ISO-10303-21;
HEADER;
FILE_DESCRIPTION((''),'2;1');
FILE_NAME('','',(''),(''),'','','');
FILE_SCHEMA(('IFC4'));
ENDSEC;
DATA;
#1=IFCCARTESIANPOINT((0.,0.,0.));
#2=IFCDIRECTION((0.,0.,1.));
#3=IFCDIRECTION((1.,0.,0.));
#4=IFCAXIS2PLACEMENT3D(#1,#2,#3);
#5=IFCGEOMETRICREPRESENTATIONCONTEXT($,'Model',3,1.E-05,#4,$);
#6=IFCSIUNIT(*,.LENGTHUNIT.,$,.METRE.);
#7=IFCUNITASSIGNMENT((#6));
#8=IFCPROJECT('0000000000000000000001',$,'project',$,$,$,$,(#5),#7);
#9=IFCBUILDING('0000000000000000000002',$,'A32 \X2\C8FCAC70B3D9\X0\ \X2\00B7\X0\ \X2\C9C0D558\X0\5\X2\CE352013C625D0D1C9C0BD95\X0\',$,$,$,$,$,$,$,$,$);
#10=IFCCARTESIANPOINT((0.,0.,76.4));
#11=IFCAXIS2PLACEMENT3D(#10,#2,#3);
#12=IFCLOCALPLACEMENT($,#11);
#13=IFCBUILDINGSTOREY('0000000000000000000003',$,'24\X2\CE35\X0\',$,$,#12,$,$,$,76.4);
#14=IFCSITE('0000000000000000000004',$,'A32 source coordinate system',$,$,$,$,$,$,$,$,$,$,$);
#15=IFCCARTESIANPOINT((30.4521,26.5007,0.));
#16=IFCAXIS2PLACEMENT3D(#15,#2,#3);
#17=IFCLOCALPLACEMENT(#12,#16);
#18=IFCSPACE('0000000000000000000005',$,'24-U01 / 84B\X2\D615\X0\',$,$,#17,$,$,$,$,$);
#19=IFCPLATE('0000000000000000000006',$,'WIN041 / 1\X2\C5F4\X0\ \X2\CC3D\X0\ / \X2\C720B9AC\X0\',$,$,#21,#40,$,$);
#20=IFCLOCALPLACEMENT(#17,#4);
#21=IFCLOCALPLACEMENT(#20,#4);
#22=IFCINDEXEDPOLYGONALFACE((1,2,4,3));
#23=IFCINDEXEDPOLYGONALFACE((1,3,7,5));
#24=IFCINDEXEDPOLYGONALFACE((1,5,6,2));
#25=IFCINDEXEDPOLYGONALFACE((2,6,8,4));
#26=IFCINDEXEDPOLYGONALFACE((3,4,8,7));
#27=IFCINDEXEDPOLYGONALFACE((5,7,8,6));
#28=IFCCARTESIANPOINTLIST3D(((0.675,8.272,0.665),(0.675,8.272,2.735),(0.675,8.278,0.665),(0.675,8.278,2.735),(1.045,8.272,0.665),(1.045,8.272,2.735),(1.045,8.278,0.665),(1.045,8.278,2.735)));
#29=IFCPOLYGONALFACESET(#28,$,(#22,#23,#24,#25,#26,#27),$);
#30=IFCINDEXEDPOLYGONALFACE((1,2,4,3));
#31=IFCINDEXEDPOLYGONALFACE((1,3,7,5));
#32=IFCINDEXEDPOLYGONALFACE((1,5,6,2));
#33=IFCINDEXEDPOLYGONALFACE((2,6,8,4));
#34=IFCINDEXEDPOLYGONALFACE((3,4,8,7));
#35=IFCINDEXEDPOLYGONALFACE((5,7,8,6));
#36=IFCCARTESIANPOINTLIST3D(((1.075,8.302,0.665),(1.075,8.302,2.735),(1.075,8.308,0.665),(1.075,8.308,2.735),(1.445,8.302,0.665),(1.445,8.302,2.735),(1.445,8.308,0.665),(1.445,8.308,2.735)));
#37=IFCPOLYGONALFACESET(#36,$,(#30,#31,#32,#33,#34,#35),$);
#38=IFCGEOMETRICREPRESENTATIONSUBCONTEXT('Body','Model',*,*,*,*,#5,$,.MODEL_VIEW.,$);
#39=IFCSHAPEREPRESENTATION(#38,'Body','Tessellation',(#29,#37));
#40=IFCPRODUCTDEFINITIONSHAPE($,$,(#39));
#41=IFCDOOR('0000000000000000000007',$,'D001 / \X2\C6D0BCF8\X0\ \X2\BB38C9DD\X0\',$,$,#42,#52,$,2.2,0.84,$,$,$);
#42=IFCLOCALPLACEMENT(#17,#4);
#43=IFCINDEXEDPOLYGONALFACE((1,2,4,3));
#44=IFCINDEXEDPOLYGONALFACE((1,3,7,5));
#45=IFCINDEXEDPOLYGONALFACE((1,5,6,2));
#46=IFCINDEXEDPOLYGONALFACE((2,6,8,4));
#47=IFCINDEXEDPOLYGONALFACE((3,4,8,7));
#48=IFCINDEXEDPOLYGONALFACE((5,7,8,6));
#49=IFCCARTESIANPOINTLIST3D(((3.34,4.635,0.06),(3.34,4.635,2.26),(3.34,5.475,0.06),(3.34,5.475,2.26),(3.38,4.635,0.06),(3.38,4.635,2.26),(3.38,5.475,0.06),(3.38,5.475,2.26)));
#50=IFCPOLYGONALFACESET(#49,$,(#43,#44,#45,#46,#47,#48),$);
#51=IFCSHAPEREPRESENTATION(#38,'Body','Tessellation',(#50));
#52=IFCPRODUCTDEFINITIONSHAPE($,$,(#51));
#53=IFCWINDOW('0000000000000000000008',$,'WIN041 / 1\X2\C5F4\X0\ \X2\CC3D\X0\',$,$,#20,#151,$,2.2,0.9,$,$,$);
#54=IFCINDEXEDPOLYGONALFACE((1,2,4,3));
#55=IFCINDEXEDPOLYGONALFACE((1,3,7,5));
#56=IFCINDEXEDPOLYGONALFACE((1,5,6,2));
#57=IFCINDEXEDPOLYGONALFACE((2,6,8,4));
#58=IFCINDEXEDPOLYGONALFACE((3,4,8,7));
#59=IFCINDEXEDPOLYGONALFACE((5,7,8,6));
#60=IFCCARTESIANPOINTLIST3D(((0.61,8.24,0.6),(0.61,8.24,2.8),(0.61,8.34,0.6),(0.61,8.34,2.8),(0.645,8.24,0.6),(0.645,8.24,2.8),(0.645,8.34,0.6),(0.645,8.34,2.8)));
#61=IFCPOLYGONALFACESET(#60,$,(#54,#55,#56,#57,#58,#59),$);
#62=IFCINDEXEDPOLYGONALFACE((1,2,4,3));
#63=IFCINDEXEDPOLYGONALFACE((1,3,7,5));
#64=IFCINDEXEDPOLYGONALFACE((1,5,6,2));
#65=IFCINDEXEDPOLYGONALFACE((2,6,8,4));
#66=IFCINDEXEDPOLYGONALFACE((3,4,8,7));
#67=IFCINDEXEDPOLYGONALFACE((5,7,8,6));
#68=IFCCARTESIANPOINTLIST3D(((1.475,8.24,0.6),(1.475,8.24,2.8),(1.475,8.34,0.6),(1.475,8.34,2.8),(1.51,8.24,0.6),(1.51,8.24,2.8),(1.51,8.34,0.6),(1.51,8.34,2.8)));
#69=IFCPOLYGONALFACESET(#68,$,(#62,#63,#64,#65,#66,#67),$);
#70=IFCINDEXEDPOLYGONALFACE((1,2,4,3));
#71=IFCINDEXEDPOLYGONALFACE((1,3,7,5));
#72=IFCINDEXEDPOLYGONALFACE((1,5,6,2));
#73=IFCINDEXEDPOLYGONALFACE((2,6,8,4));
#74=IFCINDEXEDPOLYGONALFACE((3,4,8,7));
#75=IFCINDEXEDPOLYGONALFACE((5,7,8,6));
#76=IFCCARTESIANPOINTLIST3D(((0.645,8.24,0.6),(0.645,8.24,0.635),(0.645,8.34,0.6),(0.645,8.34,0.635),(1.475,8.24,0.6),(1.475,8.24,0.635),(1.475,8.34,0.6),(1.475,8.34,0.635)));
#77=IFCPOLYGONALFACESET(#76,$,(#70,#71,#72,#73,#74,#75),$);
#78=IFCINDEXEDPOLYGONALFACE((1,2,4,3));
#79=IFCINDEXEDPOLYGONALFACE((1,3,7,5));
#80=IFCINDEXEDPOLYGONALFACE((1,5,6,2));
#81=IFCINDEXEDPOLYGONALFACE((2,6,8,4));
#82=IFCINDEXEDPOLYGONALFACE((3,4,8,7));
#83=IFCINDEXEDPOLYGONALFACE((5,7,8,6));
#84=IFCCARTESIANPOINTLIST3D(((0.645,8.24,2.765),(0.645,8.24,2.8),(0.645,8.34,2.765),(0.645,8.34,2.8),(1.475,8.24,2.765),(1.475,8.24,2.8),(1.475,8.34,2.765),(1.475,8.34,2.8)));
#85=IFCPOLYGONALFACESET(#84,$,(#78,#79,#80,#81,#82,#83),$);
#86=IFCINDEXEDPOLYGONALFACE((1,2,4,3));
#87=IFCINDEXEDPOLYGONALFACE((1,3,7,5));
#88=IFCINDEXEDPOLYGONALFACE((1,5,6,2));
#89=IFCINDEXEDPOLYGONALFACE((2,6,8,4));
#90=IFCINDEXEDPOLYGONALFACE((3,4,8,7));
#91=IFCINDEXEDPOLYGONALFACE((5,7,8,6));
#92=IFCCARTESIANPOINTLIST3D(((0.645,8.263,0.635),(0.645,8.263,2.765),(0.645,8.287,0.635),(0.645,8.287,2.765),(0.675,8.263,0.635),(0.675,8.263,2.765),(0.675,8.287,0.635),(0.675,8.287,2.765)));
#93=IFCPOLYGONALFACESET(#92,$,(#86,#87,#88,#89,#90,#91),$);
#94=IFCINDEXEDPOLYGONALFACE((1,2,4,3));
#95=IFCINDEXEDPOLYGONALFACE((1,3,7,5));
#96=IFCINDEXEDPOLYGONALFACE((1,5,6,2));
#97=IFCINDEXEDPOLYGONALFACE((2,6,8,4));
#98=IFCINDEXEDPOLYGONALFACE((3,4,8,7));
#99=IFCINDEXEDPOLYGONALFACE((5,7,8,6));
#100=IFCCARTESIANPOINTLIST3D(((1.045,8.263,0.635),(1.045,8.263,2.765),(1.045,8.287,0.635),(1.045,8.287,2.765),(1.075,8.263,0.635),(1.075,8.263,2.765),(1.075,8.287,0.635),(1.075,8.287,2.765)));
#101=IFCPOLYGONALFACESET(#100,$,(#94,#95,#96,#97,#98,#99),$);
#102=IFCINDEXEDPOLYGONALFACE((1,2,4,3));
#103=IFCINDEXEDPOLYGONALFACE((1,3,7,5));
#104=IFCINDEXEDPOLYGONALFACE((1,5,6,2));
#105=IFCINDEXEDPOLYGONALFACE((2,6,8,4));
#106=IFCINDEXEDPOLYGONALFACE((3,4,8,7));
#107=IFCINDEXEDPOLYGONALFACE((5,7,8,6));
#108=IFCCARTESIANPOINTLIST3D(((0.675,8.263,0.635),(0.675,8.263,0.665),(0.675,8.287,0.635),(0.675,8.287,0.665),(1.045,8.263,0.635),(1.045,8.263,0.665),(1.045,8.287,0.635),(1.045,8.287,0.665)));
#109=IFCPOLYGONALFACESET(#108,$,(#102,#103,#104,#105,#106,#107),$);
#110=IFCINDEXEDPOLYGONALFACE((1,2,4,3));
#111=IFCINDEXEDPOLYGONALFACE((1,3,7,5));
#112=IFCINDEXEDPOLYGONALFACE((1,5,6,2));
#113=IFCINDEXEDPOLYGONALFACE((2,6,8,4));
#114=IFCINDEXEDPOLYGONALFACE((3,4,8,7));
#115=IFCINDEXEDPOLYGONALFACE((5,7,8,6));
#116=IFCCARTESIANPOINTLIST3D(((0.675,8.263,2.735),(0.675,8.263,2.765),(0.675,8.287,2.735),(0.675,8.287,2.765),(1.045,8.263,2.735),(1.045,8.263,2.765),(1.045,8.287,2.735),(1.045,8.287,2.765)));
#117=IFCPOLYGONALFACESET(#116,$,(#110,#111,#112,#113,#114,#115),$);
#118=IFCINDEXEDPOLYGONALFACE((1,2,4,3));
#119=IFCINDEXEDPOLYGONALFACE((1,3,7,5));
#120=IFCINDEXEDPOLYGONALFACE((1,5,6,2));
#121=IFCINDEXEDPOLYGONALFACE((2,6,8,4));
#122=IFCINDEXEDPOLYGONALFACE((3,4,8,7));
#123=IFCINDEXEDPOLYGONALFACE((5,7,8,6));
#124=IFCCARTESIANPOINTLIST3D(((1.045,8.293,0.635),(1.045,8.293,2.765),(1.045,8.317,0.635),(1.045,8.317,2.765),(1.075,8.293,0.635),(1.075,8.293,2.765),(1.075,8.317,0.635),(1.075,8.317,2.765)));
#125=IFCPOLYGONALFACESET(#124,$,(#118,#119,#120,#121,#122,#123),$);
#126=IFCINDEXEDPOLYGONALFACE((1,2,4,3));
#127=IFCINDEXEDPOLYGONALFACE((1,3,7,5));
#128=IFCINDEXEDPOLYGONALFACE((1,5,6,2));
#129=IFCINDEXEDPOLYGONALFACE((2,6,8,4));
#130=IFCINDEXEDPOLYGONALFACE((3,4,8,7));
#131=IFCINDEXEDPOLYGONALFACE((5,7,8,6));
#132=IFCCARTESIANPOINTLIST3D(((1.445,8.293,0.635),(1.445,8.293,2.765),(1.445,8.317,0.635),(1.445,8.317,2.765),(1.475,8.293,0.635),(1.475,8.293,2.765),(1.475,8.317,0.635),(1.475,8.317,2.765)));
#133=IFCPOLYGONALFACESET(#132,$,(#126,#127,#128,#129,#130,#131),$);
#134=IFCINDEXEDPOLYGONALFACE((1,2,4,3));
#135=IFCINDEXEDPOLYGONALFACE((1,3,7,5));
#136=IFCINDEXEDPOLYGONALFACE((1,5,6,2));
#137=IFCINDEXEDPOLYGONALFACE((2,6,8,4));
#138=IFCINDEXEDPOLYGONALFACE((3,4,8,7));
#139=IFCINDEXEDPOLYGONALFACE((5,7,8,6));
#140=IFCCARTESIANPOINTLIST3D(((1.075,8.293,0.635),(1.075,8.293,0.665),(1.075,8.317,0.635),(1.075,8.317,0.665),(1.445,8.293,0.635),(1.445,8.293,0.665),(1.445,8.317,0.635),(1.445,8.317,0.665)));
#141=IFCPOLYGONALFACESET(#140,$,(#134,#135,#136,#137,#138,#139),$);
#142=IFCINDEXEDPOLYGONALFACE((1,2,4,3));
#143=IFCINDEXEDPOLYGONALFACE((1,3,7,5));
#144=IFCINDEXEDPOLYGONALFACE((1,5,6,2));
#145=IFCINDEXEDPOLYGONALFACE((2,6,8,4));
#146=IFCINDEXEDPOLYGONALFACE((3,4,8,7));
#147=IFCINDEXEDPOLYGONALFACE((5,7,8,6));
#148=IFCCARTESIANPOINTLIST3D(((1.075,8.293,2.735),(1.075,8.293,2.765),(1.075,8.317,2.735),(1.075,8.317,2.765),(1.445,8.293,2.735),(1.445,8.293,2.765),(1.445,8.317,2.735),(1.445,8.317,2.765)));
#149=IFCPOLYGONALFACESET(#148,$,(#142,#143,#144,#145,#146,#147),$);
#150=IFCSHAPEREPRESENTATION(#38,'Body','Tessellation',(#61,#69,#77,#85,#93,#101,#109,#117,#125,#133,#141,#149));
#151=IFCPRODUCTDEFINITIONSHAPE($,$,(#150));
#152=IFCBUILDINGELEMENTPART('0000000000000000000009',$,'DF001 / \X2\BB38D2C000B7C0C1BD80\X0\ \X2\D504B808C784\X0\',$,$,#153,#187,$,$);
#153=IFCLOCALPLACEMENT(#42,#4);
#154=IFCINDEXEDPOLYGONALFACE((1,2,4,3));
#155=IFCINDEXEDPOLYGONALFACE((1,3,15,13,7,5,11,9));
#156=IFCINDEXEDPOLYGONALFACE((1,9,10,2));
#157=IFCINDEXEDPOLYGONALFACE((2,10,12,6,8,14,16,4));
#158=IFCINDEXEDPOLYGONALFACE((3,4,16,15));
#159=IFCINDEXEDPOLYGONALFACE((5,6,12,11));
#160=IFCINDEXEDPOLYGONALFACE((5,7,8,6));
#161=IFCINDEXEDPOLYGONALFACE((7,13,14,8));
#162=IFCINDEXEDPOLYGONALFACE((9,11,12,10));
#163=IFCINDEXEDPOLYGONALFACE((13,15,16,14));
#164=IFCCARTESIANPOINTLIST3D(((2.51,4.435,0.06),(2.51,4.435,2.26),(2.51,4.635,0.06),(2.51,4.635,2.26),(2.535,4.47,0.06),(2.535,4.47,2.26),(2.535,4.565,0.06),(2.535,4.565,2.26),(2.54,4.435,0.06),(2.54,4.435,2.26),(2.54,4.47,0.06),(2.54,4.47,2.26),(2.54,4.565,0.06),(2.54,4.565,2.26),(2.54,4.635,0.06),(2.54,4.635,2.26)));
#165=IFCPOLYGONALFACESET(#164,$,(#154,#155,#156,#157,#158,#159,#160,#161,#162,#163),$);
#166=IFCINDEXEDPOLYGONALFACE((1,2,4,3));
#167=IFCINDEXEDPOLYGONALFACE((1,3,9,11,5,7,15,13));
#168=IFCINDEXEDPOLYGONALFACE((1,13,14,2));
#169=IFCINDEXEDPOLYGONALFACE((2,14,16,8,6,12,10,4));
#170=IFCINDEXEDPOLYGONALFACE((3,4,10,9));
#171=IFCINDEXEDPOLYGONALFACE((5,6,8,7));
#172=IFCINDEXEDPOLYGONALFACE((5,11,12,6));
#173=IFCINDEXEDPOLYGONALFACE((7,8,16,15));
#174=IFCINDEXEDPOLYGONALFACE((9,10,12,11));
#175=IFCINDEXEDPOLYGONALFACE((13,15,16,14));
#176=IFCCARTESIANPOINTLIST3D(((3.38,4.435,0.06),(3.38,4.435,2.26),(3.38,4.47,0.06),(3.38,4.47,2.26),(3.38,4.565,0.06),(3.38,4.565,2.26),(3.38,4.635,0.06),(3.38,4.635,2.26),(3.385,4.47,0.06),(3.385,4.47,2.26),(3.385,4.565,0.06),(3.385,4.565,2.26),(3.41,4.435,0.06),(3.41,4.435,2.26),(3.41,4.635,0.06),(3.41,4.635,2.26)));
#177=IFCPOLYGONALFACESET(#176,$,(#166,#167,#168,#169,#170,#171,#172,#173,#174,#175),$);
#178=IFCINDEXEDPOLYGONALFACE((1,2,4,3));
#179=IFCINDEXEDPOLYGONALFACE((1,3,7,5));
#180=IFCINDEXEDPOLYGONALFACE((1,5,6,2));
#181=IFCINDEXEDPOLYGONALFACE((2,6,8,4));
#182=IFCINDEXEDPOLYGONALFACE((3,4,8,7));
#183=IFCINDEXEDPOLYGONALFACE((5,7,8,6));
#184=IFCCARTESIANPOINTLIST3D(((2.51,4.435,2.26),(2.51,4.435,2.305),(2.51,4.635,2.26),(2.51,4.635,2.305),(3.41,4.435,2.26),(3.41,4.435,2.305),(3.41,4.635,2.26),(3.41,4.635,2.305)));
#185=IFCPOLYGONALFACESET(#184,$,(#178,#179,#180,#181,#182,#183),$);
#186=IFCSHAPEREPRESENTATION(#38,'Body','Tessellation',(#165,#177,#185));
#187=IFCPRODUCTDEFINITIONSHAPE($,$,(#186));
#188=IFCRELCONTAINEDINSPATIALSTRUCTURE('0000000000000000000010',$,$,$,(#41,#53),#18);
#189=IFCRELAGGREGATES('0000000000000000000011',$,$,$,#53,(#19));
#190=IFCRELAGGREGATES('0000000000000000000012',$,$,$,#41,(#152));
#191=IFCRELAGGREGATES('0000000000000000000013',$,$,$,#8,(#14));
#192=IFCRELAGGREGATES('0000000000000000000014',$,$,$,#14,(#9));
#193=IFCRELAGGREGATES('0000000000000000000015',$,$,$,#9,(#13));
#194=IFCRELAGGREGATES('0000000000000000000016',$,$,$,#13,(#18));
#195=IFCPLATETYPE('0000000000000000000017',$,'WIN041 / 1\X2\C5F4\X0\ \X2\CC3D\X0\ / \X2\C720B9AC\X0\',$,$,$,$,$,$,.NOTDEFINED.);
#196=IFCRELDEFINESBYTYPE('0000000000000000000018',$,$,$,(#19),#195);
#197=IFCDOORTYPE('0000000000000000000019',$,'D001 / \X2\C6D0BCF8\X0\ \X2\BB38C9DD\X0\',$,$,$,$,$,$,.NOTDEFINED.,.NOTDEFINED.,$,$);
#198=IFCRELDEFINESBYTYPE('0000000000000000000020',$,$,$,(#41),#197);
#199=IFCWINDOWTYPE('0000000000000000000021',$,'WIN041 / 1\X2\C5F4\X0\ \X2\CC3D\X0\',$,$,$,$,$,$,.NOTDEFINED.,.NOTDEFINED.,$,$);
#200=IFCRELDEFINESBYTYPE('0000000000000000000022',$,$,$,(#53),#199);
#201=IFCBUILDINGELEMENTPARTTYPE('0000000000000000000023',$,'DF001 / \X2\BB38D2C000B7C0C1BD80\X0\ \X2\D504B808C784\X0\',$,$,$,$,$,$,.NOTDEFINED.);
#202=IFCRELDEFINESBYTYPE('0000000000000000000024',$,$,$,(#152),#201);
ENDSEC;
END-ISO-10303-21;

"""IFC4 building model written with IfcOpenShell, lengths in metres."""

from ifc_helpers import new_model, si_unit, frame, origin, origin_with_axes, place, context, subcontext, project, spatial, polyline, outline, extrude, source, transform, mapped, type_object, type_shapes, element, aggregate, save


model = new_model("IFC4")

# Units and contexts
model_context = context("Model", 3, precision=1e-05, world=origin_with_axes())
body_context = subcontext(model_context, "Body", "Model", "MODEL_VIEW")
ifc_project = project(units=[si_unit("LENGTHUNIT", "METRE")], contexts=[model_context])

# Plate
storey_placement = place(None, frame((0.0, 0.0, 76.4), z_axis=(0.0, 0.0, 1.0), x_axis=(1.0, 0.0, 0.0)))
space_placement = place(storey_placement, frame((30.4521, 26.5007, 0.0), z_axis=(0.0, 0.0, 1.0), x_axis=(1.0, 0.0, 0.0)))
plate_type_1 = type_object("IfcPlateType", Name="WIN041 / 1열 창 / 유리", PredefinedType="NOTDEFINED")
shared_shape_1 = source(origin(), body_context, "Body", "SweptSolid", [
    extrude(outline(polyline([(0.675, 8.272), (0.675, 8.278), (1.045, 8.278), (1.045, 8.272), (0.675, 8.272)])), frame((0.0, 0.0, 0.665)), (0.0, 0.0, 1.0), 2.07),
    extrude(outline(polyline([(1.075, 8.302), (1.075, 8.308), (1.445, 8.308), (1.445, 8.302), (1.075, 8.302)])), frame((0.0, 0.0, 0.665)), (0.0, 0.0, 1.0), 2.07),
])
type_shapes(plate_type_1, [shared_shape_1])
window_1_placement = place(space_placement, origin_with_axes())
plate_1_placement = place(window_1_placement, origin_with_axes())
plate_1 = element("IfcPlate", 1, at=plate_1_placement, type_object=plate_type_1, Name="WIN041 / 1열 창 / 유리", context=body_context, shape_type="MappedRepresentation", body=[
    mapped(shared_shape_1, transform((0.0, 0.0, 0.0), scale=1.0)),
])

# Site, building, storey, space
site = spatial("IfcSite", under=ifc_project, Name="A32 source coordinate system")
building = spatial("IfcBuilding", under=site, Name="A32 주거동 · 지하5층–옥탑지붕")
storey = spatial("IfcBuildingStorey", under=building, at=storey_placement, Name="24층", Elevation=76.4)
space = spatial("IfcSpace", under=storey, at=space_placement, Name="24-U01 / 84B형")

# Door
door_type_1 = type_object("IfcDoorType", Name="D001 / 원본 문짝", OperationType="NOTDEFINED", PredefinedType="NOTDEFINED")
shared_shape_2 = source(origin(), body_context, "Body", "SweptSolid", [
    extrude(outline(polyline([(3.34, 5.475), (3.38, 5.475), (3.38, 4.635), (3.34, 4.635), (3.34, 5.475)])), frame((0.0, 0.0, 0.06)), (0.0, 0.0, 1.0), 2.2),
])
type_shapes(door_type_1, [shared_shape_2])
door_1_placement = place(space_placement, origin_with_axes())
door_1 = element("IfcDoor", 2, at=door_1_placement, inside=space, type_object=door_type_1, Name="D001 / 원본 문짝", OverallHeight=2.2, OverallWidth=0.84, context=body_context, shape_type="MappedRepresentation", body=[
    mapped(shared_shape_2, transform((0.0, 0.0, 0.0), scale=1.0)),
])

# Window
window_type_1 = type_object("IfcWindowType", Name="WIN041 / 1열 창", PartitioningType="NOTDEFINED", PredefinedType="NOTDEFINED")
shared_shape_3 = source(origin(), body_context, "Body", "SweptSolid", [
    extrude(outline(polyline([(0.61, 8.24), (0.61, 8.34), (0.645, 8.34), (0.645, 8.24), (0.61, 8.24)])), frame((0.0, 0.0, 0.6)), (0.0, 0.0, 1.0), 2.2),
    extrude(outline(polyline([(1.475, 8.24), (1.475, 8.34), (1.51, 8.34), (1.51, 8.24), (1.475, 8.24)])), frame((0.0, 0.0, 0.6)), (0.0, 0.0, 1.0), 2.2),
    extrude(outline(polyline([(0.645, 8.24), (0.645, 8.34), (1.475, 8.34), (1.475, 8.24), (0.645, 8.24)])), frame((0.0, 0.0, 0.6)), (0.0, 0.0, 1.0), 0.035),
    extrude(outline(polyline([(0.645, 8.24), (0.645, 8.34), (1.475, 8.34), (1.475, 8.24), (0.645, 8.24)])), frame((0.0, 0.0, 2.765)), (0.0, 0.0, 1.0), 0.035),
    extrude(outline(polyline([(0.645, 8.263), (0.645, 8.287), (0.675, 8.287), (0.675, 8.263), (0.645, 8.263)])), frame((0.0, 0.0, 0.635)), (0.0, 0.0, 1.0), 2.13),
    extrude(outline(polyline([(1.045, 8.263), (1.045, 8.287), (1.075, 8.287), (1.075, 8.263), (1.045, 8.263)])), frame((0.0, 0.0, 0.635)), (0.0, 0.0, 1.0), 2.13),
    extrude(outline(polyline([(0.675, 8.263), (0.675, 8.287), (1.045, 8.287), (1.045, 8.263), (0.675, 8.263)])), frame((0.0, 0.0, 0.635)), (0.0, 0.0, 1.0), 0.03),
    extrude(outline(polyline([(0.675, 8.263), (0.675, 8.287), (1.045, 8.287), (1.045, 8.263), (0.675, 8.263)])), frame((0.0, 0.0, 2.735)), (0.0, 0.0, 1.0), 0.03),
    extrude(outline(polyline([(1.045, 8.293), (1.045, 8.317), (1.075, 8.317), (1.075, 8.293), (1.045, 8.293)])), frame((0.0, 0.0, 0.635)), (0.0, 0.0, 1.0), 2.13),
    extrude(outline(polyline([(1.445, 8.293), (1.445, 8.317), (1.475, 8.317), (1.475, 8.293), (1.445, 8.293)])), frame((0.0, 0.0, 0.635)), (0.0, 0.0, 1.0), 2.13),
    extrude(outline(polyline([(1.075, 8.293), (1.075, 8.317), (1.445, 8.317), (1.445, 8.293), (1.075, 8.293)])), frame((0.0, 0.0, 0.635)), (0.0, 0.0, 1.0), 0.03),
    extrude(outline(polyline([(1.075, 8.293), (1.075, 8.317), (1.445, 8.317), (1.445, 8.293), (1.075, 8.293)])), frame((0.0, 0.0, 2.735)), (0.0, 0.0, 1.0), 0.03),
])
type_shapes(window_type_1, [shared_shape_3])
window_1 = element("IfcWindow", 3, at=window_1_placement, inside=space, type_object=window_type_1, Name="WIN041 / 1열 창", OverallHeight=2.2, OverallWidth=0.9, context=body_context, shape_type="MappedRepresentation", body=[
    mapped(shared_shape_3, transform((0.0, 0.0, 0.0), scale=1.0)),
])
aggregate(window_1, [plate_1])

# Building element part
building_element_part_type_1 = type_object("IfcBuildingElementPartType", Name="DF001 / 문틀·상부 프레임", PredefinedType="NOTDEFINED")
shared_shape_4 = source(origin(), body_context, "Body", "SweptSolid", [
    extrude(outline(polyline([(2.54, 4.635), (2.54, 4.565), (2.535, 4.565), (2.535, 4.47), (2.54, 4.47), (2.54, 4.435), (2.51, 4.435), (2.51, 4.635), (2.54, 4.635)])), frame((0.0, 0.0, 0.06)), (0.0, 0.0, 1.0), 2.2),
    extrude(outline(polyline([(3.41, 4.435), (3.38, 4.435), (3.38, 4.47), (3.385, 4.47), (3.385, 4.565), (3.38, 4.565), (3.38, 4.635), (3.41, 4.635), (3.41, 4.435)])), frame((0.0, 0.0, 0.06)), (0.0, 0.0, 1.0), 2.2),
    extrude(outline(polyline([(2.51, 4.435), (2.51, 4.635), (3.41, 4.635), (3.41, 4.435), (2.51, 4.435)])), frame((0.0, 0.0, 2.26)), (0.0, 0.0, 1.0), 0.045),
])
type_shapes(building_element_part_type_1, [shared_shape_4])
building_element_part_1_placement = place(door_1_placement, origin_with_axes())
building_element_part_1 = element("IfcBuildingElementPart", 4, at=building_element_part_1_placement, type_object=building_element_part_type_1, Name="DF001 / 문틀·상부 프레임", context=body_context, shape_type="MappedRepresentation", body=[
    mapped(shared_shape_4, transform((0.0, 0.0, 0.0), scale=1.0)),
])
aggregate(door_1, [building_element_part_1])

save(model, "model.ifc")
